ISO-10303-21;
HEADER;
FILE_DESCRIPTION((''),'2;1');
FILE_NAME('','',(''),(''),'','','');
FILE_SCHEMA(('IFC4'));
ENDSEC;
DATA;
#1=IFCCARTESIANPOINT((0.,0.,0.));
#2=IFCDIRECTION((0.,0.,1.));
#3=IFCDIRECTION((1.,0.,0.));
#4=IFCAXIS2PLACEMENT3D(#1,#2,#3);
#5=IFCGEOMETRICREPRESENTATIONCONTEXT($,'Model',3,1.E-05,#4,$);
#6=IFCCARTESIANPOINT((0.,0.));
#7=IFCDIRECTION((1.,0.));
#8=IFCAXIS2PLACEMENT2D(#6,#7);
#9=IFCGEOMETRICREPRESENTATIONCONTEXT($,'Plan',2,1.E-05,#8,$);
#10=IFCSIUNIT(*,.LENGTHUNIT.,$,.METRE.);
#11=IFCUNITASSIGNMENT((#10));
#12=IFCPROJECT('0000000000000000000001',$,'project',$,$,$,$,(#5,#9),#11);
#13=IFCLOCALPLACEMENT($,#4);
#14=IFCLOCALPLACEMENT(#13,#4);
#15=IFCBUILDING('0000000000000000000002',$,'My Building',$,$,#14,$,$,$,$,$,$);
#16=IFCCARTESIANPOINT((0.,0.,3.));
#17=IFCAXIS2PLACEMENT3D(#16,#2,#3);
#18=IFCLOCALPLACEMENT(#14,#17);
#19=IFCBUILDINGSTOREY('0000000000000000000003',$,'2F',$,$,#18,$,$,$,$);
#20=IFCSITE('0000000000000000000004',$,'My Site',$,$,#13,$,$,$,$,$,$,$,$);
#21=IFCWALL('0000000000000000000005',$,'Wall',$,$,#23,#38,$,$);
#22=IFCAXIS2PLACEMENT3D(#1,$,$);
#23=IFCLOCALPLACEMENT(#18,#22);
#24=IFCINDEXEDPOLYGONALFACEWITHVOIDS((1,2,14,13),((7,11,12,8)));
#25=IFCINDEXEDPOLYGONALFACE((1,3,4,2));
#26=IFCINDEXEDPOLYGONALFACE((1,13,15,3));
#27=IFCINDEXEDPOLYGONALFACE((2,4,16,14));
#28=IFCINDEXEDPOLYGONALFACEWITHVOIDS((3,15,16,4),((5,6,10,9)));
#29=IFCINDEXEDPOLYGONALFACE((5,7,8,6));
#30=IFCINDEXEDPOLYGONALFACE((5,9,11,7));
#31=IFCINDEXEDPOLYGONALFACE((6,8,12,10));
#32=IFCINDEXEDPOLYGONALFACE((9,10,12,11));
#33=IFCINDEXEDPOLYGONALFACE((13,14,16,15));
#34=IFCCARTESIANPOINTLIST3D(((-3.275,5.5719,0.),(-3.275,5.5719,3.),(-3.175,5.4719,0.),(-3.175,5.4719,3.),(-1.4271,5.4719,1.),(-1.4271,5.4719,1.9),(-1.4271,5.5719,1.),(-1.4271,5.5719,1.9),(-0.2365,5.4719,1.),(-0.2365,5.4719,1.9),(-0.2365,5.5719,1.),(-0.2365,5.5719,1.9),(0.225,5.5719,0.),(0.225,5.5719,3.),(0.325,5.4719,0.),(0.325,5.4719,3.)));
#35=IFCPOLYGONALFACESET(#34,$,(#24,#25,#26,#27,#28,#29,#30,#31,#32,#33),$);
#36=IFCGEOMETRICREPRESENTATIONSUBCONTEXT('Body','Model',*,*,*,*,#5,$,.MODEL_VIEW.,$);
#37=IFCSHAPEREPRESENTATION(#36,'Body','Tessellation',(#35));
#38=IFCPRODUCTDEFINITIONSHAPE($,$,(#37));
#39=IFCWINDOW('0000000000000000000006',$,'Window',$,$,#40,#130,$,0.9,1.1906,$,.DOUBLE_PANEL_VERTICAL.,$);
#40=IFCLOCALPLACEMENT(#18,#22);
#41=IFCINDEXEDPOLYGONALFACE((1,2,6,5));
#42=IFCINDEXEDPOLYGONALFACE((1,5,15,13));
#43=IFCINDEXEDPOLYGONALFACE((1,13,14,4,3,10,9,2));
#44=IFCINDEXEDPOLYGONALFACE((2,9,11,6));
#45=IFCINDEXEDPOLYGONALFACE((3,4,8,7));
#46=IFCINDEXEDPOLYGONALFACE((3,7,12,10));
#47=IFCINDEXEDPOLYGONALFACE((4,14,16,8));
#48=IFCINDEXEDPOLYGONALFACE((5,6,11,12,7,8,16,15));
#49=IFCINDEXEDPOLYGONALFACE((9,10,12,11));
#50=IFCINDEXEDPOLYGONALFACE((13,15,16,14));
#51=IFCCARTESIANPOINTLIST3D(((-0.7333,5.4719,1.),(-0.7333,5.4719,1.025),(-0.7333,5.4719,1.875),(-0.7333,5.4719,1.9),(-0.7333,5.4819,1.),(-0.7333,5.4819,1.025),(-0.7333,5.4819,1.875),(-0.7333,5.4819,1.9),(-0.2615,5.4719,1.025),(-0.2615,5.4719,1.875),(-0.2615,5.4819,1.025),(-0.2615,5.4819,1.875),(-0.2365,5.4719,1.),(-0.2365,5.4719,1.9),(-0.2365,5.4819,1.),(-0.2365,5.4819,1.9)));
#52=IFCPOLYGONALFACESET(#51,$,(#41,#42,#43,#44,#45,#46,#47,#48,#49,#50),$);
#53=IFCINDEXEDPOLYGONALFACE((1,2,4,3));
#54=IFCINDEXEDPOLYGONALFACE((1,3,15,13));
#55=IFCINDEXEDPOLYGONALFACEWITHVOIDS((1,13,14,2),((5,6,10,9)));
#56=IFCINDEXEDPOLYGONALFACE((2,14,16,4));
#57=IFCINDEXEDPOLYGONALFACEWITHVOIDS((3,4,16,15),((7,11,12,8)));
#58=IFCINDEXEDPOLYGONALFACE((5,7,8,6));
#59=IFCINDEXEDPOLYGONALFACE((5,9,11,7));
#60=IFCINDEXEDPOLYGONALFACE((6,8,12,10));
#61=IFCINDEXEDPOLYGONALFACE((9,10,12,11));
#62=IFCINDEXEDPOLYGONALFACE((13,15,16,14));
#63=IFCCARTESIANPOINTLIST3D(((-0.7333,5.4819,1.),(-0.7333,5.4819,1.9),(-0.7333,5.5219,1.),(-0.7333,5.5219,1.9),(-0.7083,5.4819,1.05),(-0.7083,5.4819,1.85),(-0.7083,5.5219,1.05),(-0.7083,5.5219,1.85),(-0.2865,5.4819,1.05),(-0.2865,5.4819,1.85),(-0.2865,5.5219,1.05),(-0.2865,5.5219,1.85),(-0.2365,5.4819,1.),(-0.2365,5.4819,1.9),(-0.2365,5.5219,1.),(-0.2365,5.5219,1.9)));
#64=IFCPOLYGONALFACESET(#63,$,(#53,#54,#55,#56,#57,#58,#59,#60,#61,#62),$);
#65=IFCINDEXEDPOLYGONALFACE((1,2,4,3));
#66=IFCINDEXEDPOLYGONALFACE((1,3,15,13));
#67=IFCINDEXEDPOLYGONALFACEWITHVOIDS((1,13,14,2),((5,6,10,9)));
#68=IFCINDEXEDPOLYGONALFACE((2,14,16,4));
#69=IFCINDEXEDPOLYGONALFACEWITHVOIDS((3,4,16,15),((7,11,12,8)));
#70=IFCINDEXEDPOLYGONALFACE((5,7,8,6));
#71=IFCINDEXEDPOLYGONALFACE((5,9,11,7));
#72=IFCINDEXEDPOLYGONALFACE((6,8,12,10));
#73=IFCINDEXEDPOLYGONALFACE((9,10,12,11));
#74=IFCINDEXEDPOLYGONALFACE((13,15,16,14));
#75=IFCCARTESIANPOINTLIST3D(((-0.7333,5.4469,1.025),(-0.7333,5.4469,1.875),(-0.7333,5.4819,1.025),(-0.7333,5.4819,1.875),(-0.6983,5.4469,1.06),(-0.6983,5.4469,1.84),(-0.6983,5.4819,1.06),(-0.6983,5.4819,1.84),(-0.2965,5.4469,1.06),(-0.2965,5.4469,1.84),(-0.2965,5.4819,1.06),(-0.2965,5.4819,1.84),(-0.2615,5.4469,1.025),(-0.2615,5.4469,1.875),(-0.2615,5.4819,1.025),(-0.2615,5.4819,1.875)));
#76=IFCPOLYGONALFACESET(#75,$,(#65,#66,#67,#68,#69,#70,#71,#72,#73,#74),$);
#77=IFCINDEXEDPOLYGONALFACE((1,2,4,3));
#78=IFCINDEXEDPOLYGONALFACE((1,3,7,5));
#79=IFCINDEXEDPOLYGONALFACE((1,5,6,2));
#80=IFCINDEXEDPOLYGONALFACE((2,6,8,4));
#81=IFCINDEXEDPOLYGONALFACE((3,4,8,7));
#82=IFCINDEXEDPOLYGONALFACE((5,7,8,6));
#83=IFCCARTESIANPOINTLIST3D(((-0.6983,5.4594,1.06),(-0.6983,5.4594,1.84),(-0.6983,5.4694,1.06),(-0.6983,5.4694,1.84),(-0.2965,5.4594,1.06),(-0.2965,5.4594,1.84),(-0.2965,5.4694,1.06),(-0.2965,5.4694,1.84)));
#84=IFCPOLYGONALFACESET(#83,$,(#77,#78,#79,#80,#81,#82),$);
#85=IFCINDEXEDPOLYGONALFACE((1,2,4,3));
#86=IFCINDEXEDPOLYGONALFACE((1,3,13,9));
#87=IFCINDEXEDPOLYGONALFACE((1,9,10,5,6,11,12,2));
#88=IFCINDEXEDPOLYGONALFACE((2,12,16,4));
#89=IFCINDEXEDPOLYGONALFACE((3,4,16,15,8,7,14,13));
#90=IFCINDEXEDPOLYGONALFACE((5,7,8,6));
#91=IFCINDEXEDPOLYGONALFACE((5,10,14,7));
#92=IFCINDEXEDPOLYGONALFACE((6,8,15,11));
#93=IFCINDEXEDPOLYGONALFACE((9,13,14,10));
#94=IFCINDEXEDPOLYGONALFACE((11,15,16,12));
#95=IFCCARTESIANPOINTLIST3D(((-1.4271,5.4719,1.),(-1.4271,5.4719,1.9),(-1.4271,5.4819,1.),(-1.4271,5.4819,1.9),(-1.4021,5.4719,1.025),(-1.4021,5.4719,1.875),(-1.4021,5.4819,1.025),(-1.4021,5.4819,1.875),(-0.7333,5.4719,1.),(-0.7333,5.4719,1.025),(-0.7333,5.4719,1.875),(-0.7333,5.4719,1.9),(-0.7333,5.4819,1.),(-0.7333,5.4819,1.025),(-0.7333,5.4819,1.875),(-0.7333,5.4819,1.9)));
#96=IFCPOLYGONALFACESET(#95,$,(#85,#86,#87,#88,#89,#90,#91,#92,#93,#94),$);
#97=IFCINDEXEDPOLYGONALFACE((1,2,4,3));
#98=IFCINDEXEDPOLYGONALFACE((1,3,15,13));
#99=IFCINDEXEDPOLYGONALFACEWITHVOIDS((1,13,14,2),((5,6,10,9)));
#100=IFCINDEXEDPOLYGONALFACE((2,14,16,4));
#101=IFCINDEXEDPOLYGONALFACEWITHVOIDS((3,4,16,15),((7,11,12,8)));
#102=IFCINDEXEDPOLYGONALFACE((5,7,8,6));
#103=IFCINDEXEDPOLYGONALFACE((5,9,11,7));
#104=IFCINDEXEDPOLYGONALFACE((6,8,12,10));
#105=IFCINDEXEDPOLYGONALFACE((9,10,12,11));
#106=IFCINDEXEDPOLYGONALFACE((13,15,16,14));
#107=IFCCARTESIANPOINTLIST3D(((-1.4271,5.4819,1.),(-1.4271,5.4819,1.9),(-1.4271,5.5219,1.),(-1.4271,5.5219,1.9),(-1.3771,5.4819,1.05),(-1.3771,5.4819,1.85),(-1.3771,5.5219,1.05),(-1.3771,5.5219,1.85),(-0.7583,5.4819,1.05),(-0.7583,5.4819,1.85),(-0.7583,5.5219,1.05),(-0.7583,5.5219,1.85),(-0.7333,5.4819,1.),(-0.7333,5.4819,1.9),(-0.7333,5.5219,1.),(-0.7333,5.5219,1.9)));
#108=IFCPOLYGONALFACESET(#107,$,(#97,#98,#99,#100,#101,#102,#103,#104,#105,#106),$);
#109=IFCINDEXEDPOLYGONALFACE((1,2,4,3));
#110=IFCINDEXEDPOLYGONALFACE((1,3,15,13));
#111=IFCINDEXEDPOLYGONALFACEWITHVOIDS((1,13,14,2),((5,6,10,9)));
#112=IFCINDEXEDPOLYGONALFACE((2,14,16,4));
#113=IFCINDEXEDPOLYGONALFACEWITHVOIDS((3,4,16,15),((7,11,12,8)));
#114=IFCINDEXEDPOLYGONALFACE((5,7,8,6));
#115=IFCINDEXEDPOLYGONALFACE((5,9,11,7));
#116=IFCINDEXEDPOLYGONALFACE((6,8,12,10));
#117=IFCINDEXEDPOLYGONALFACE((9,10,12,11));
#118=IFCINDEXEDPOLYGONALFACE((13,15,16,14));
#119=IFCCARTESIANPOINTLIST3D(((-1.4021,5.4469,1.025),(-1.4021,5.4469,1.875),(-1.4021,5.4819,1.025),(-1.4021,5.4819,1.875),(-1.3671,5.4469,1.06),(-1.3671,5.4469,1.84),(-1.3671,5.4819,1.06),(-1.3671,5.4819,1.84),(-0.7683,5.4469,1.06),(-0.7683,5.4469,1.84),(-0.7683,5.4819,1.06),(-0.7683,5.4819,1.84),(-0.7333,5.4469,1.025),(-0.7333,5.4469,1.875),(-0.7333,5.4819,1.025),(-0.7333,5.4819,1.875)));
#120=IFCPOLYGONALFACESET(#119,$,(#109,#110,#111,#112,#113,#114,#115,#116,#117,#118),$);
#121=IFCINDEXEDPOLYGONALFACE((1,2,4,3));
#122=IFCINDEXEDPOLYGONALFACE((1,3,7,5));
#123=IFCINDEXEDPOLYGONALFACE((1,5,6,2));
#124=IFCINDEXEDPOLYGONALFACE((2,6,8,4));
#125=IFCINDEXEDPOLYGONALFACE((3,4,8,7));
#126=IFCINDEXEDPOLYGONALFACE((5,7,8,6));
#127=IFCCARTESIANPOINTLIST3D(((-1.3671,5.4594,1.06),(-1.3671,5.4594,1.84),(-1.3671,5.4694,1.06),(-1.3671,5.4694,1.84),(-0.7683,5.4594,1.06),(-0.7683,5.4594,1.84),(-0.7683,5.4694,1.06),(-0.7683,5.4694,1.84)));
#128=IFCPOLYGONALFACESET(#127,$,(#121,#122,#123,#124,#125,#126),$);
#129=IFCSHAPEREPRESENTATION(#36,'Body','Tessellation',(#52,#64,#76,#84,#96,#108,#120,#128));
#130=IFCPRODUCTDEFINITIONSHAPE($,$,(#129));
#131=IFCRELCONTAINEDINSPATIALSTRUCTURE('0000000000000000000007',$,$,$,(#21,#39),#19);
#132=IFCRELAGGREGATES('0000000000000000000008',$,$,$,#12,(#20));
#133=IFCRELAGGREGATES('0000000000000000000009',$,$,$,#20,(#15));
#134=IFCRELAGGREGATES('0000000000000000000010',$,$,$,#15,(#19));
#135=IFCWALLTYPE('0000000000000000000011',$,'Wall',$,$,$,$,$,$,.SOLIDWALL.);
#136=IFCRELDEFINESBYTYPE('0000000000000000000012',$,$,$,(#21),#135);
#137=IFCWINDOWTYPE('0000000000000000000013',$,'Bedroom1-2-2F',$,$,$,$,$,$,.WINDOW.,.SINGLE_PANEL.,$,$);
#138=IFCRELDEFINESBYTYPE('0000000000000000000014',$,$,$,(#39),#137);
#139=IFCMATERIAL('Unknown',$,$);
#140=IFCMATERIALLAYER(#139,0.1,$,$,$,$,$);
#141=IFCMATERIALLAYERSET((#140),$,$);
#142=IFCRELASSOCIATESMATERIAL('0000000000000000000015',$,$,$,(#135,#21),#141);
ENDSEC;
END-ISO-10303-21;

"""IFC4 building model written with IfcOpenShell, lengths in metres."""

from ifc_helpers import new_model, entity, si_unit, frame, origin_with_axes, origin_2d_with_axis, place, context, subcontext, project, spatial, line, indexed_curve, outline, extrude, shape, source, transform, mapped, material, layer, layer_set, layer_usage, type_object, type_shapes, element, fill, save


model = new_model("IFC4")

# Units and contexts
model_context = context("Model", 3, precision=1e-05, world=origin_with_axes())
plan_context = context("Plan", 2, precision=1e-05, world=origin_2d_with_axis())
body_context_1 = subcontext(model_context, "Body", "Model", "MODEL_VIEW")
body_context_2 = subcontext(plan_context, "Body", "Plan", "PLAN_VIEW")
ifc_project = project(units=[si_unit("LENGTHUNIT", "METRE")], contexts=[model_context, plan_context])

# Site, building, storey
site_placement = place(None, origin_with_axes())
site = spatial("IfcSite", under=ifc_project, at=site_placement, Name="My Site")
building_placement = place(site_placement, origin_with_axes())
building = spatial("IfcBuilding", under=site, at=building_placement, Name="My Building")
storey_placement = place(building_placement, frame((0.0, 0.0, 3.0), z_axis=(0.0, 0.0, 1.0), x_axis=(1.0, 0.0, 0.0)))
storey = spatial("IfcBuildingStorey", under=building, at=storey_placement, Name="2F")

# Shared definitions
ifc_material = material(Name="Unknown")

# Shared definitions
ifc_layer_1 = layer(ifc_material, 0.1)
ifc_layer_set_1 = layer_set([ifc_layer_1])
wall_type = type_object("IfcWallType", Name="Wall", PredefinedType="SOLIDWALL", material=ifc_layer_set_1)

# Wall, opening, window
ifc_layer_usage_1 = layer_usage(ifc_layer_set_1, "AXIS2", "POSITIVE", 0.0)
wall_1_placement = place(storey_placement, frame((0.225, 5.5719, 0.0), z_axis=(0.0, 0.0, 1.0), x_axis=(-1.0, 0.0, 0.0)))
wall_1 = element("IfcWall", 1, at=wall_1_placement, inside=storey, type_object=wall_type, material=ifc_layer_usage_1, Name="Wall", context=body_context_1, shape_type="SweptSolid", body=[
    extrude(outline(indexed_curve([(0.0, 0.0), (-0.1, 0.1), (3.4, 0.1), (3.5, 0.0)], segments=[line(1, 2, 3, 4, 1)])), origin_with_axes(), (0.0, 0.0, 1.0), 3.0),
])
shared_shape_1 = source(origin_with_axes(), body_context_1, "Body", "SweptSolid", [
    extrude(outline(indexed_curve([(0.0, 0.0), (1.1906, 0.0), (1.1906, 0.9), (0.0, 0.9)], segments=[line(1, 2, 3, 4, 1)])), frame((0.0, -0.6, 0.0), z_axis=(0.0, -1.0, 0.0), x_axis=(1.0, 0.0, 0.0)), (0.0, 0.0, -1.0), 1.2),
])
opening_1_placement = place(wall_1_placement, frame((0.4615, 0.0, 1.0), z_axis=(0.0, 0.0, 1.0), x_axis=(1.0, 0.0, 0.0)))
opening_1 = element("IfcOpeningElement", 2, at=opening_1_placement, cuts=wall_1, PredefinedType="OPENING", context=body_context_1, shape_type="MappedRepresentation", body=[
    mapped(shared_shape_1, transform((0.0, 0.0, 0.0), x_axis=(1.0, 0.0, 0.0), y_axis=(0.0, 1.0, 0.0), z_axis=(0.0, 0.0, 1.0), scale=1.0)),
])
window_type_1 = type_object("IfcWindowType", Name="Bedroom1-2-2F", PartitioningType="SINGLE_PANEL", PredefinedType="WINDOW")
shared_shape_2 = source(origin_with_axes(), body_context_1, "Body", "SweptSolid", [
    extrude(outline(indexed_curve([(0.4967, 0.0), (0.0, 0.0), (0.0, 0.9), (0.4967, 0.9), (0.4967, 0.875), (0.025, 0.875), (0.025, 0.025), (0.4967, 0.025)], segments=[line(1, 2, 3, 4, 5, 6, 7, 8, 1)])), frame((0.0, 0.09, 0.0), z_axis=(0.0, -1.0, 0.0), x_axis=(1.0, 0.0, 0.0)), (0.0, 0.0, -1.0), 0.01),
    extrude(outline(indexed_curve([(0.0, 0.0), (0.4967, 0.0), (0.4967, 0.9), (0.0, 0.9)], segments=[line(1, 2, 3, 4, 1)]), holes=[indexed_curve([(0.05, 0.05), (0.4717, 0.05), (0.4717, 0.85), (0.05, 0.85)], segments=[line(1, 2, 3, 4, 1)])]), frame((0.0, 0.05, 0.0), z_axis=(0.0, -1.0, 0.0), x_axis=(1.0, 0.0, 0.0)), (0.0, 0.0, -1.0), 0.04),
    extrude(outline(indexed_curve([(0.0, 0.0), (0.4717, 0.0), (0.4717, 0.85), (0.0, 0.85)], segments=[line(1, 2, 3, 4, 1)]), holes=[indexed_curve([(0.035, 0.035), (0.4367, 0.035), (0.4367, 0.815), (0.035, 0.815)], segments=[line(1, 2, 3, 4, 1)])]), frame((0.025, 0.09, 0.025), z_axis=(0.0, -1.0, 0.0), x_axis=(1.0, 0.0, 0.0)), (0.0, 0.0, -1.0), 0.035),
    extrude(outline(indexed_curve([(0.035, 0.035), (0.4367, 0.035), (0.4367, 0.815), (0.035, 0.815)], segments=[line(1, 2, 3, 4, 1)])), frame((0.025, 0.1025, 0.025), z_axis=(0.0, -1.0, 0.0), x_axis=(1.0, 0.0, 0.0)), (0.0, 0.0, -1.0), 0.01),
    extrude(outline(indexed_curve([(0.0, 0.9), (0.6938, 0.9), (0.6938, 0.0), (0.0, 0.0), (0.0, 0.025), (0.6688, 0.025), (0.6688, 0.875), (0.0, 0.875)], segments=[line(1, 2, 3, 4, 5, 6, 7, 8, 1)])), frame((0.4967, 0.09, 0.0), z_axis=(0.0, -1.0, 0.0), x_axis=(1.0, 0.0, 0.0)), (0.0, 0.0, -1.0), 0.01),
    extrude(outline(indexed_curve([(0.0, 0.0), (0.6938, 0.0), (0.6938, 0.9), (0.0, 0.9)], segments=[line(1, 2, 3, 4, 1)]), holes=[indexed_curve([(0.025, 0.05), (0.6438, 0.05), (0.6438, 0.85), (0.025, 0.85)], segments=[line(1, 2, 3, 4, 1)])]), frame((0.4967, 0.05, 0.0), z_axis=(0.0, -1.0, 0.0), x_axis=(1.0, 0.0, 0.0)), (0.0, 0.0, -1.0), 0.04),
    extrude(outline(indexed_curve([(0.0, 0.0), (0.6688, 0.0), (0.6688, 0.85), (0.0, 0.85)], segments=[line(1, 2, 3, 4, 1)]), holes=[indexed_curve([(0.035, 0.035), (0.6338, 0.035), (0.6338, 0.815), (0.035, 0.815)], segments=[line(1, 2, 3, 4, 1)])]), frame((0.4967, 0.09, 0.025), z_axis=(0.0, -1.0, 0.0), x_axis=(1.0, 0.0, 0.0)), (0.0, 0.0, -1.0), 0.035),
    extrude(outline(indexed_curve([(0.035, 0.035), (0.6338, 0.035), (0.6338, 0.815), (0.035, 0.815)], segments=[line(1, 2, 3, 4, 1)])), frame((0.4967, 0.1025, 0.025), z_axis=(0.0, -1.0, 0.0), x_axis=(1.0, 0.0, 0.0)), (0.0, 0.0, -1.0), 0.01),
])
shared_shape_3 = source(origin_with_axes(), body_context_2, "Body", "Curve2D", [
    entity("IfcIndexedPolyCurve", entity("IfcCartesianPointList2D", [[0.05, 0.05], [0.4717, 0.05]])),
    entity("IfcIndexedPolyCurve", entity("IfcCartesianPointList2D", [[0.0, 0.1], [0.025, 0.1], [0.025, 0.09], [0.05, 0.09], [0.05, 0.05], [0.0, 0.05]]), [entity("IfcLineIndex", [1, 2, 3, 4, 5, 6, 1])]),
    entity("IfcIndexedPolyCurve", entity("IfcCartesianPointList2D", [[0.4967, 0.1], [0.4967, 0.1], [0.4967, 0.09], [0.4717, 0.09], [0.4717, 0.05], [0.4967, 0.05]])),
    entity("IfcIndexedPolyCurve", entity("IfcCartesianPointList2D", [[0.025, 0.09], [0.06, 0.09], [0.06, 0.125], [0.025, 0.125]]), [entity("IfcLineIndex", [1, 2, 3, 4, 1])]),
    entity("IfcIndexedPolyCurve", entity("IfcCartesianPointList2D", [[0.4967, 0.09], [0.4617, 0.09], [0.4617, 0.125], [0.4967, 0.125]]), [entity("IfcLineIndex", [1, 2, 3, 4, 1])]),
    entity("IfcIndexedPolyCurve", entity("IfcCartesianPointList2D", [[0.06, 0.09], [0.4617, 0.09]])),
    entity("IfcIndexedPolyCurve", entity("IfcCartesianPointList2D", [[0.06, 0.125], [0.4617, 0.125]])),
    entity("IfcIndexedPolyCurve", entity("IfcCartesianPointList2D", [[0.06, 0.1075], [0.4617, 0.1075]])),
    entity("IfcIndexedPolyCurve", entity("IfcCartesianPointList2D", [[0.5217, 0.05], [1.1406, 0.05]])),
    entity("IfcIndexedPolyCurve", entity("IfcCartesianPointList2D", [[0.4967, 0.1], [0.4967, 0.1], [0.4967, 0.09], [0.5217, 0.09], [0.5217, 0.05], [0.4967, 0.05]])),
    entity("IfcIndexedPolyCurve", entity("IfcCartesianPointList2D", [[1.1906, 0.1], [1.1656, 0.1], [1.1656, 0.09], [1.1406, 0.09], [1.1406, 0.05], [1.1906, 0.05]]), [entity("IfcLineIndex", [1, 2, 3, 4, 5, 6, 1])]),
    entity("IfcIndexedPolyCurve", entity("IfcCartesianPointList2D", [[0.4967, 0.09], [0.5317, 0.09], [0.5317, 0.125], [0.4967, 0.125]]), [entity("IfcLineIndex", [1, 2, 3, 4, 1])]),
    entity("IfcIndexedPolyCurve", entity("IfcCartesianPointList2D", [[1.1656, 0.09], [1.1306, 0.09], [1.1306, 0.125], [1.1656, 0.125]]), [entity("IfcLineIndex", [1, 2, 3, 4, 1])]),
    entity("IfcIndexedPolyCurve", entity("IfcCartesianPointList2D", [[0.5317, 0.09], [1.1306, 0.09]])),
    entity("IfcIndexedPolyCurve", entity("IfcCartesianPointList2D", [[0.5317, 0.125], [1.1306, 0.125]])),
    entity("IfcIndexedPolyCurve", entity("IfcCartesianPointList2D", [[0.5317, 0.1075], [1.1306, 0.1075]])),
])
type_shapes(window_type_1, [shared_shape_2, shared_shape_3])
window_1_placement = place(opening_1_placement, origin_with_axes())
window_1 = element("IfcWindow", 3, at=window_1_placement, inside=storey, type_object=window_type_1, Name="Window", OverallHeight=0.9, OverallWidth=1.1906, PartitioningType="DOUBLE_PANEL_VERTICAL", shapes=[
    shape(body_context_1, "Body", "MappedRepresentation", [mapped(shared_shape_2, transform((0.0, 0.0, 0.0), x_axis=(1.0, 0.0, 0.0), y_axis=(0.0, 1.0, 0.0), z_axis=(0.0, 0.0, 1.0), scale=1.0))]),
    shape(body_context_2, "Body", "MappedRepresentation", [mapped(shared_shape_3, transform((0.0, 0.0, 0.0), x_axis=(1.0, 0.0, 0.0), y_axis=(0.0, 1.0, 0.0), z_axis=(0.0, 0.0, 1.0), scale=1.0))]),
])
fill(opening_1, window_1)

save(model, "model.ifc")
